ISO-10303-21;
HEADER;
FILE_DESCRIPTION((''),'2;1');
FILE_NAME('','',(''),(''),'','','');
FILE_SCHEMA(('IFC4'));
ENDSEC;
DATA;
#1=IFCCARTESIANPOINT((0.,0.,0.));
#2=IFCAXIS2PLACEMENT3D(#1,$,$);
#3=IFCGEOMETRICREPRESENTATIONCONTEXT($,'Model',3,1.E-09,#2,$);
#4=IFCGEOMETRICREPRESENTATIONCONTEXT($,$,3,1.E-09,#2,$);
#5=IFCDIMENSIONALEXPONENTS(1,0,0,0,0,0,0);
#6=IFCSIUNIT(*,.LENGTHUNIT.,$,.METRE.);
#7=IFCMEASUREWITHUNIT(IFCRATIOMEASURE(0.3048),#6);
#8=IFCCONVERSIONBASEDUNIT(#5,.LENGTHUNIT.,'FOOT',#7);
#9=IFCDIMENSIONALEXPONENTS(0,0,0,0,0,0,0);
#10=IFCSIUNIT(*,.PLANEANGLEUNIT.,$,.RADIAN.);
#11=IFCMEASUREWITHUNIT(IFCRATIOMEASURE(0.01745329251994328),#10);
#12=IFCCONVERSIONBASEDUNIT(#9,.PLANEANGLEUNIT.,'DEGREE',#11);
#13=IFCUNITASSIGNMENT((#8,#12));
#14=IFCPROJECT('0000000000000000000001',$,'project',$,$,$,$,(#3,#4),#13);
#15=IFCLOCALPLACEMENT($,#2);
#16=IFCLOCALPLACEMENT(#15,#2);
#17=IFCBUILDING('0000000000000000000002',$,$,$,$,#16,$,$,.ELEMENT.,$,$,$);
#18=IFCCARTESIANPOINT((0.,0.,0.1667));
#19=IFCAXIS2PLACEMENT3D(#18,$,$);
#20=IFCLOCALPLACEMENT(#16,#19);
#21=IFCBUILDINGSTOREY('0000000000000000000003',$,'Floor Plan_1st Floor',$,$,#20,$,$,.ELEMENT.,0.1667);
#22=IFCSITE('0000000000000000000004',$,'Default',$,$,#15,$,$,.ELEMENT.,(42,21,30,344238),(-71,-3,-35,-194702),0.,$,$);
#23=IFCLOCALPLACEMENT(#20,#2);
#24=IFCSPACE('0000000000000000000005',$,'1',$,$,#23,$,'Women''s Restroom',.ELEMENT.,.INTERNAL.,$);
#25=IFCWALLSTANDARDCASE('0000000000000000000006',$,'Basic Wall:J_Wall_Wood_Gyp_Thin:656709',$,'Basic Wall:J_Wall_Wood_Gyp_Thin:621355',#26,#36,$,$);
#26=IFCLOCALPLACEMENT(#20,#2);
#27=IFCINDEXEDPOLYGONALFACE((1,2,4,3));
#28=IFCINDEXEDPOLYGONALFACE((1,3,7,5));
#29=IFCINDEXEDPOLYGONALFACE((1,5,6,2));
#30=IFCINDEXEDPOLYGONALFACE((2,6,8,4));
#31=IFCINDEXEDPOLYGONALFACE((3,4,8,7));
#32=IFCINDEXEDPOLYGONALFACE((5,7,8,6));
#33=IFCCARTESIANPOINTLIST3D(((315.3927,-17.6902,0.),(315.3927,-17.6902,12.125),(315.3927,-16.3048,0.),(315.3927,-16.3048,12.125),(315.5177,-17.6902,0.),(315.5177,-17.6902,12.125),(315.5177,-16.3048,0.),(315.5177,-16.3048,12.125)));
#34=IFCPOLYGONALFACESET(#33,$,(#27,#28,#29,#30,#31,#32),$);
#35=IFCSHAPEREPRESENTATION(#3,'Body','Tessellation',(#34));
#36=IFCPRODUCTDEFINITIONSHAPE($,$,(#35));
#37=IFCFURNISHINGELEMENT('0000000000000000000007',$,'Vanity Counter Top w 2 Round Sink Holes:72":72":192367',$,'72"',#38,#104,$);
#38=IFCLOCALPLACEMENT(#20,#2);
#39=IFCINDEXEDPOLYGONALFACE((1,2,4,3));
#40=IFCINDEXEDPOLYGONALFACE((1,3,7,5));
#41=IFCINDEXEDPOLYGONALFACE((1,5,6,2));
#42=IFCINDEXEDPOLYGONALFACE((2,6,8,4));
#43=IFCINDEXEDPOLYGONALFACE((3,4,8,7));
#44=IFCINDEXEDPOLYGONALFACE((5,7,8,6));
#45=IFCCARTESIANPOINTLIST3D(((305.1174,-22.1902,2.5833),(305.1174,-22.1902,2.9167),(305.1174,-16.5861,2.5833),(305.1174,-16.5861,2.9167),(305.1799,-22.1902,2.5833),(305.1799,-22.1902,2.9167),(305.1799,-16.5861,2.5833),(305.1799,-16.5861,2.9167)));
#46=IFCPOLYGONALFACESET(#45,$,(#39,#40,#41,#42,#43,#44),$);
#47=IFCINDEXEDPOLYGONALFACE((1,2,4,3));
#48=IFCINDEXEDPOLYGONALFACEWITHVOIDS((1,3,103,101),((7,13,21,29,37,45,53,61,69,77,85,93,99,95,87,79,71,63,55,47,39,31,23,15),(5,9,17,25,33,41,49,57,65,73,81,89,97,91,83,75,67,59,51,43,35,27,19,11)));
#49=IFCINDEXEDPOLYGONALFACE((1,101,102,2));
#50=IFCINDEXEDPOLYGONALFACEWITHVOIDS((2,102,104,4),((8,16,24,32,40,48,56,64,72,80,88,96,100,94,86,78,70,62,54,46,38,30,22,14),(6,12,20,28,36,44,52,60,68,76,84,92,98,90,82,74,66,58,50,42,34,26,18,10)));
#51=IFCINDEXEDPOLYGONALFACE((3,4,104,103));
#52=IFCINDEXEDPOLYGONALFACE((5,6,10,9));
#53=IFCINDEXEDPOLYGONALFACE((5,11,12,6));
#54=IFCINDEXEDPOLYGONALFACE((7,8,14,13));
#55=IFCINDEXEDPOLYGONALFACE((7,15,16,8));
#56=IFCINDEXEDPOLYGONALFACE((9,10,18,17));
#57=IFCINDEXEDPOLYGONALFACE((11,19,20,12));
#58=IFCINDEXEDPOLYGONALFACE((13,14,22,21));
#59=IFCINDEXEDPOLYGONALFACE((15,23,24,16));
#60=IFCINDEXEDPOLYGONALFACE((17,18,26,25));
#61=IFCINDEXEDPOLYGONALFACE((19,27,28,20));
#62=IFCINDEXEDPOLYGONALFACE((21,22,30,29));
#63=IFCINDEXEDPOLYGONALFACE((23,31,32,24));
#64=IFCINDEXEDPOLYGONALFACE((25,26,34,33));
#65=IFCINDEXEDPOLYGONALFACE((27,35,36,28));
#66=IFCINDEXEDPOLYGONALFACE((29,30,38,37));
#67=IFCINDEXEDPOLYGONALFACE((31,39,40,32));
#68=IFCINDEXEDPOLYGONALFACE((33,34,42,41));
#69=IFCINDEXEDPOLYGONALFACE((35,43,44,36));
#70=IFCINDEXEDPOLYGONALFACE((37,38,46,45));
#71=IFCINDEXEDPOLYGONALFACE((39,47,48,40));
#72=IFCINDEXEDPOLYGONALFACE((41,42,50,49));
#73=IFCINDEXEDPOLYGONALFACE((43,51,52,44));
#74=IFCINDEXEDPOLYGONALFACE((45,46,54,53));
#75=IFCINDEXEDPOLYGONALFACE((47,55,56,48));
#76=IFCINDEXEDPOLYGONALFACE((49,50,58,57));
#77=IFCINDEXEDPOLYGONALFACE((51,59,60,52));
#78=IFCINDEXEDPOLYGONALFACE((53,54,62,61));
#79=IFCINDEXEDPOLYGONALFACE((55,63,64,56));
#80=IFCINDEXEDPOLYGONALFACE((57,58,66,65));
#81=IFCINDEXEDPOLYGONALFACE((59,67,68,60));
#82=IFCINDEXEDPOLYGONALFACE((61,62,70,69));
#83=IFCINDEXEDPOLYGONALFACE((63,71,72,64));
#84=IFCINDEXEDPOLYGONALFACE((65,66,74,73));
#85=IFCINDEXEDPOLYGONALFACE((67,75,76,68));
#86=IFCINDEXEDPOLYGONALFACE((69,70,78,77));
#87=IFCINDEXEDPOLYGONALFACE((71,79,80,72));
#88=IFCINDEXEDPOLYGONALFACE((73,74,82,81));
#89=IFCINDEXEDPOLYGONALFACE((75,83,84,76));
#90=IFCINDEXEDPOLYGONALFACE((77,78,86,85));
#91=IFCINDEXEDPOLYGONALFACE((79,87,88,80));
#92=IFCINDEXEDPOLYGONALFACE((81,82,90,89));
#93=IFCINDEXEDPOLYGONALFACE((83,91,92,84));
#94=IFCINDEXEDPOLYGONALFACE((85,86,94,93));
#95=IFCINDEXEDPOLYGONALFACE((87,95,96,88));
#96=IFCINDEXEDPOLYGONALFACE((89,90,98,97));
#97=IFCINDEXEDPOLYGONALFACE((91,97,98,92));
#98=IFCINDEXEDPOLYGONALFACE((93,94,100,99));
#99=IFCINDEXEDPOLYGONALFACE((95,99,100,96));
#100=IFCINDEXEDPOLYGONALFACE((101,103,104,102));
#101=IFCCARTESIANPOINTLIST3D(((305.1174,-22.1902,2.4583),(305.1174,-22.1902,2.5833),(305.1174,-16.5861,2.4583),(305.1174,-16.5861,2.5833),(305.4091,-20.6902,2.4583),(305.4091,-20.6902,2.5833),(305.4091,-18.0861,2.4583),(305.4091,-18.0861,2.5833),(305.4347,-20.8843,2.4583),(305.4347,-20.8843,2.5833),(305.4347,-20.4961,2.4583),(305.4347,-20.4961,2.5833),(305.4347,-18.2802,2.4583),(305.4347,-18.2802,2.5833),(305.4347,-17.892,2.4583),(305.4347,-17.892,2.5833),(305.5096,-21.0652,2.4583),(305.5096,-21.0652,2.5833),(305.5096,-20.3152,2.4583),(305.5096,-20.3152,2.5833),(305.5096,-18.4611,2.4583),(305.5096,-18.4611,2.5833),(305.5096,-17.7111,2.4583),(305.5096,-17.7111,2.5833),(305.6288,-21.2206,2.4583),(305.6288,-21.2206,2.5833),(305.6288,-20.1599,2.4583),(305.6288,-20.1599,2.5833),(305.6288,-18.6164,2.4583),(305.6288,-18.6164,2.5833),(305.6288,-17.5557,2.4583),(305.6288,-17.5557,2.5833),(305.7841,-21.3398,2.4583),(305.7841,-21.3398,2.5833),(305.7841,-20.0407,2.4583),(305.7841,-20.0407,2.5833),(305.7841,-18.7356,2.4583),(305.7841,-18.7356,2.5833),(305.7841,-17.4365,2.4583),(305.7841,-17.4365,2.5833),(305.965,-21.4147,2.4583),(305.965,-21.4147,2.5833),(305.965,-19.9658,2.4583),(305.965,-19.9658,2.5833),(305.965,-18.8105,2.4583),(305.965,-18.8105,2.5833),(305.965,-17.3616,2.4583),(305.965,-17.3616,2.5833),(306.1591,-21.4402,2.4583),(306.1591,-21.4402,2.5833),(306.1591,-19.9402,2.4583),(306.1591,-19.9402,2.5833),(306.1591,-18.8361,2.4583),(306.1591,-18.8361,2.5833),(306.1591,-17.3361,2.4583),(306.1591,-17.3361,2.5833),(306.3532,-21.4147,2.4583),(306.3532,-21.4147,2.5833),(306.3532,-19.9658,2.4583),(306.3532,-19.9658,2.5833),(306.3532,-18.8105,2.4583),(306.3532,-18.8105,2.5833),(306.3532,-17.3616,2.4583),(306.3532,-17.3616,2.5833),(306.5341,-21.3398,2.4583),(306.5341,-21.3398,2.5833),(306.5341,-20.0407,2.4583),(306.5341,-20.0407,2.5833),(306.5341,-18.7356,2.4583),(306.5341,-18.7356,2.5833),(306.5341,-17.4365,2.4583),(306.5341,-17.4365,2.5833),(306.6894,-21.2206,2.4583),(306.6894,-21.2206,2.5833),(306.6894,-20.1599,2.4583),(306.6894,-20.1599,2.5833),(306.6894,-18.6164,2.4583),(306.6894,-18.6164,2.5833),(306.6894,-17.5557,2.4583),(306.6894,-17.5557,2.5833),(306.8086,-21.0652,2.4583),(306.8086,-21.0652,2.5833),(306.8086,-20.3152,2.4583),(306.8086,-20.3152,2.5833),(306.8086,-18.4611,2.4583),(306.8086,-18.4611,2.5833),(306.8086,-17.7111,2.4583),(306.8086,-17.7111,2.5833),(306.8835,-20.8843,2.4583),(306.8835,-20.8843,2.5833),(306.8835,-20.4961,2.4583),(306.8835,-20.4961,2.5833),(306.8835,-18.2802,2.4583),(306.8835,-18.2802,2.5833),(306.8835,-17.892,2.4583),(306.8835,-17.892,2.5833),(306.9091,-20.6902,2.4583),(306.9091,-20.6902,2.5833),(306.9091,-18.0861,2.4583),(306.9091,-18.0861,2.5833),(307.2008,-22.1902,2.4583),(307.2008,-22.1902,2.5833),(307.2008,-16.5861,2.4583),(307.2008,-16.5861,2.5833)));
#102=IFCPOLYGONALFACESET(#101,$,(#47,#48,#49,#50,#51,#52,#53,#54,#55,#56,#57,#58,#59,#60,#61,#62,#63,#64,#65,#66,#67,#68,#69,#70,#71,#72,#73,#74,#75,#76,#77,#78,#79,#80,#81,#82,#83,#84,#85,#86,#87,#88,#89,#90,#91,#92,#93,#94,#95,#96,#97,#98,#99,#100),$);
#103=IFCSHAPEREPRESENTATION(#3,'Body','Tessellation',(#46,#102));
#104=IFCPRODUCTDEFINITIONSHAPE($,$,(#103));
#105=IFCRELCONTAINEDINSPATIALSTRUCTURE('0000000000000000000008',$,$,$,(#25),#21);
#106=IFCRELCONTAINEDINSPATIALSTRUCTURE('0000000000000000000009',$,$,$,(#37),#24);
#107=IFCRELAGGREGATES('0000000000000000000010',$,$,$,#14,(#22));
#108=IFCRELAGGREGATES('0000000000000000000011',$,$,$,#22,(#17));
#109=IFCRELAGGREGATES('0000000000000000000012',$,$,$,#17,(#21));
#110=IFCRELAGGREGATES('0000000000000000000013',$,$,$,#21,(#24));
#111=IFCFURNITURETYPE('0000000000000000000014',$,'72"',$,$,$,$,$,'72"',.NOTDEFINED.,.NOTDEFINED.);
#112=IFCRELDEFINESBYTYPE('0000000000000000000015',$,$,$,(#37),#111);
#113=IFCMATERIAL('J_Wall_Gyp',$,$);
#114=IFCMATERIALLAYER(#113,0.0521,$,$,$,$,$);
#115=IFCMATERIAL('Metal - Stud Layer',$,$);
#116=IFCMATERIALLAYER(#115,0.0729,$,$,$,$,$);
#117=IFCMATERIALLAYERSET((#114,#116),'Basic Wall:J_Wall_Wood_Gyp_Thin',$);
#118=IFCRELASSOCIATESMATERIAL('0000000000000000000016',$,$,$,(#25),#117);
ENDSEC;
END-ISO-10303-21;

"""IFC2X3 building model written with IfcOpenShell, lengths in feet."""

from ifc_helpers import new_model, entity, si_unit, converted_unit, frame, frame_2d, origin, origin_2d_with_axis, place, context, project, spatial, polyline, circle_curve, parameter, trimmed, segment, composite_curve, rectangle, outline, extrude, clip, halfspace, source, transform, mapped, material, layer, layer_set, layer_usage, type_object, type_shapes, element, save


model = new_model("IFC2X3")

# Units and contexts
model_context = context("Model", 3, precision=1e-09, world=origin())
context_of_model = context(None, 3, precision=1e-09, world=origin())
ifc_project = project(units=[converted_unit("LENGTHUNIT", "FOOT", entity("IfcRatioMeasure", 0.3048), si_unit("LENGTHUNIT", "METRE"), dimensions=[1, 0, 0, 0, 0, 0, 0]), converted_unit("PLANEANGLEUNIT", "DEGREE", entity("IfcRatioMeasure", 0.01745329251994328), si_unit("PLANEANGLEUNIT", "RADIAN"), dimensions=[0, 0, 0, 0, 0, 0, 0])], contexts=[model_context, context_of_model])

# Site, building, storey
site_placement = place(None, origin())
site = spatial("IfcSite", under=ifc_project, at=site_placement, Name="Default", CompositionType="ELEMENT", RefLatitude=(42, 21, 30, 344238), RefLongitude=(-71, -3, -35, -194702), RefElevation=0.0)
building_placement = place(site_placement, origin())
building = spatial("IfcBuilding", under=site, at=building_placement, CompositionType="ELEMENT")
storey_placement = place(building_placement, frame((0.0, 0.0, 0.1667)))
storey = spatial("IfcBuildingStorey", under=building, at=storey_placement, Name="Floor Plan_1st Floor", CompositionType="ELEMENT", Elevation=0.1667)

# Wall
ifc_material_1 = material(Name="J_Wall_Gyp")
ifc_layer_1 = layer(ifc_material_1, 0.0521)
ifc_material_2 = material(Name="Metal - Stud Layer")
ifc_layer_2 = layer(ifc_material_2, 0.0729)
ifc_layer_set_1 = layer_set([ifc_layer_1, ifc_layer_2], Name="Basic Wall:J_Wall_Wood_Gyp_Thin")
ifc_layer_usage_1 = layer_usage(ifc_layer_set_1, "AXIS2", "POSITIVE", -0.0625)
wall_1_placement = place(storey_placement, frame((315.4552, -17.6902, 0.0), z_axis=(0.0, 0.0, 1.0), x_axis=(0.0, 1.0, 0.0)))
element("IfcWallStandardCase", 1, at=wall_1_placement, inside=storey, material=ifc_layer_usage_1, Name="Basic Wall:J_Wall_Wood_Gyp_Thin:656709", ObjectType="Basic Wall:J_Wall_Wood_Gyp_Thin:621355", context=model_context, shape_type="Clipping", body=[
    clip(extrude(rectangle(XDim=1.3854, YDim=0.125, at=frame_2d((0.6927, 0.0), x_axis=(-1.0, 0.0))), origin(), (0.0, 0.0, 1.0), 12.125), halfspace(origin(), True)),
])

# Shared definitions
space_1_placement = place(storey_placement, origin())
space_1 = spatial("IfcSpace", under=storey, at=space_1_placement, Name="1", LongName="Women's Restroom", CompositionType="ELEMENT", InteriorOrExteriorSpace="INTERNAL")

# Furnishing element
furniture_type_1 = type_object("IfcFurnitureType", Name="72\"", ElementType="72\"", AssemblyPlace="NOTDEFINED")
shared_shape_1 = source(origin(), model_context, "Body", "SweptSolid", [
    extrude(rectangle(XDim=5.6042, YDim=0.0625, at=origin_2d_with_axis()), frame((-1.5531, 0.0313, 2.5833)), (0.0, 0.0, 1.0), 0.3333),
    extrude(outline(polyline([(-1.0417, -2.8021), (1.0417, -2.8021), (1.0417, 2.8021), (-1.0417, 2.8021), (-1.0417, -2.8021)]), holes=[composite_curve([segment(trimmed(circle_curve(frame_2d((0.0, 1.3021), x_axis=(0.0, -1.0)), 0.75), [parameter(180.0)], [parameter(0.0)], True, "PARAMETER"), False, "CONTINUOUS"), segment(trimmed(circle_curve(frame_2d((0.0, 1.3021), x_axis=(0.0, -1.0)), 0.75), [parameter(360.0)], [parameter(180.0)], True, "PARAMETER"), False, "CONTINUOUS")], self_intersect=False), composite_curve([segment(trimmed(circle_curve(frame_2d((0.0, -1.3021), x_axis=(0.0, -1.0)), 0.75), [parameter(180.0)], [parameter(360.0)], True, "PARAMETER"), False, "CONTINUOUS"), segment(trimmed(circle_curve(frame_2d((0.0, -1.3021), x_axis=(0.0, -1.0)), 0.75), [parameter(0.0)], [parameter(180.0)], True, "PARAMETER"), False, "CONTINUOUS")], self_intersect=False)]), frame((-1.5531, 1.0417, 2.4583), z_axis=(0.0, 0.0, 1.0), x_axis=(0.0, 1.0, 0.0)), (0.0, 0.0, 1.0), 0.125),
])
type_shapes(furniture_type_1, [shared_shape_1])
furnishing_1_placement = place(space_1_placement, frame((305.1174, -20.9413, 0.0), z_axis=(0.0, 0.0, 1.0), x_axis=(0.0, -1.0, 0.0)))
element("IfcFurnishingElement", 2, at=furnishing_1_placement, inside=space_1, type_object=furniture_type_1, Name="Vanity Counter Top w 2 Round Sink Holes:72\":72\":192367", ObjectType="72\"", context=model_context, shape_type="MappedRepresentation", body=[
    mapped(shared_shape_1, transform((0.0, 0.0, 0.0), scale=1.0)),
])

save(model, "model.ifc")
